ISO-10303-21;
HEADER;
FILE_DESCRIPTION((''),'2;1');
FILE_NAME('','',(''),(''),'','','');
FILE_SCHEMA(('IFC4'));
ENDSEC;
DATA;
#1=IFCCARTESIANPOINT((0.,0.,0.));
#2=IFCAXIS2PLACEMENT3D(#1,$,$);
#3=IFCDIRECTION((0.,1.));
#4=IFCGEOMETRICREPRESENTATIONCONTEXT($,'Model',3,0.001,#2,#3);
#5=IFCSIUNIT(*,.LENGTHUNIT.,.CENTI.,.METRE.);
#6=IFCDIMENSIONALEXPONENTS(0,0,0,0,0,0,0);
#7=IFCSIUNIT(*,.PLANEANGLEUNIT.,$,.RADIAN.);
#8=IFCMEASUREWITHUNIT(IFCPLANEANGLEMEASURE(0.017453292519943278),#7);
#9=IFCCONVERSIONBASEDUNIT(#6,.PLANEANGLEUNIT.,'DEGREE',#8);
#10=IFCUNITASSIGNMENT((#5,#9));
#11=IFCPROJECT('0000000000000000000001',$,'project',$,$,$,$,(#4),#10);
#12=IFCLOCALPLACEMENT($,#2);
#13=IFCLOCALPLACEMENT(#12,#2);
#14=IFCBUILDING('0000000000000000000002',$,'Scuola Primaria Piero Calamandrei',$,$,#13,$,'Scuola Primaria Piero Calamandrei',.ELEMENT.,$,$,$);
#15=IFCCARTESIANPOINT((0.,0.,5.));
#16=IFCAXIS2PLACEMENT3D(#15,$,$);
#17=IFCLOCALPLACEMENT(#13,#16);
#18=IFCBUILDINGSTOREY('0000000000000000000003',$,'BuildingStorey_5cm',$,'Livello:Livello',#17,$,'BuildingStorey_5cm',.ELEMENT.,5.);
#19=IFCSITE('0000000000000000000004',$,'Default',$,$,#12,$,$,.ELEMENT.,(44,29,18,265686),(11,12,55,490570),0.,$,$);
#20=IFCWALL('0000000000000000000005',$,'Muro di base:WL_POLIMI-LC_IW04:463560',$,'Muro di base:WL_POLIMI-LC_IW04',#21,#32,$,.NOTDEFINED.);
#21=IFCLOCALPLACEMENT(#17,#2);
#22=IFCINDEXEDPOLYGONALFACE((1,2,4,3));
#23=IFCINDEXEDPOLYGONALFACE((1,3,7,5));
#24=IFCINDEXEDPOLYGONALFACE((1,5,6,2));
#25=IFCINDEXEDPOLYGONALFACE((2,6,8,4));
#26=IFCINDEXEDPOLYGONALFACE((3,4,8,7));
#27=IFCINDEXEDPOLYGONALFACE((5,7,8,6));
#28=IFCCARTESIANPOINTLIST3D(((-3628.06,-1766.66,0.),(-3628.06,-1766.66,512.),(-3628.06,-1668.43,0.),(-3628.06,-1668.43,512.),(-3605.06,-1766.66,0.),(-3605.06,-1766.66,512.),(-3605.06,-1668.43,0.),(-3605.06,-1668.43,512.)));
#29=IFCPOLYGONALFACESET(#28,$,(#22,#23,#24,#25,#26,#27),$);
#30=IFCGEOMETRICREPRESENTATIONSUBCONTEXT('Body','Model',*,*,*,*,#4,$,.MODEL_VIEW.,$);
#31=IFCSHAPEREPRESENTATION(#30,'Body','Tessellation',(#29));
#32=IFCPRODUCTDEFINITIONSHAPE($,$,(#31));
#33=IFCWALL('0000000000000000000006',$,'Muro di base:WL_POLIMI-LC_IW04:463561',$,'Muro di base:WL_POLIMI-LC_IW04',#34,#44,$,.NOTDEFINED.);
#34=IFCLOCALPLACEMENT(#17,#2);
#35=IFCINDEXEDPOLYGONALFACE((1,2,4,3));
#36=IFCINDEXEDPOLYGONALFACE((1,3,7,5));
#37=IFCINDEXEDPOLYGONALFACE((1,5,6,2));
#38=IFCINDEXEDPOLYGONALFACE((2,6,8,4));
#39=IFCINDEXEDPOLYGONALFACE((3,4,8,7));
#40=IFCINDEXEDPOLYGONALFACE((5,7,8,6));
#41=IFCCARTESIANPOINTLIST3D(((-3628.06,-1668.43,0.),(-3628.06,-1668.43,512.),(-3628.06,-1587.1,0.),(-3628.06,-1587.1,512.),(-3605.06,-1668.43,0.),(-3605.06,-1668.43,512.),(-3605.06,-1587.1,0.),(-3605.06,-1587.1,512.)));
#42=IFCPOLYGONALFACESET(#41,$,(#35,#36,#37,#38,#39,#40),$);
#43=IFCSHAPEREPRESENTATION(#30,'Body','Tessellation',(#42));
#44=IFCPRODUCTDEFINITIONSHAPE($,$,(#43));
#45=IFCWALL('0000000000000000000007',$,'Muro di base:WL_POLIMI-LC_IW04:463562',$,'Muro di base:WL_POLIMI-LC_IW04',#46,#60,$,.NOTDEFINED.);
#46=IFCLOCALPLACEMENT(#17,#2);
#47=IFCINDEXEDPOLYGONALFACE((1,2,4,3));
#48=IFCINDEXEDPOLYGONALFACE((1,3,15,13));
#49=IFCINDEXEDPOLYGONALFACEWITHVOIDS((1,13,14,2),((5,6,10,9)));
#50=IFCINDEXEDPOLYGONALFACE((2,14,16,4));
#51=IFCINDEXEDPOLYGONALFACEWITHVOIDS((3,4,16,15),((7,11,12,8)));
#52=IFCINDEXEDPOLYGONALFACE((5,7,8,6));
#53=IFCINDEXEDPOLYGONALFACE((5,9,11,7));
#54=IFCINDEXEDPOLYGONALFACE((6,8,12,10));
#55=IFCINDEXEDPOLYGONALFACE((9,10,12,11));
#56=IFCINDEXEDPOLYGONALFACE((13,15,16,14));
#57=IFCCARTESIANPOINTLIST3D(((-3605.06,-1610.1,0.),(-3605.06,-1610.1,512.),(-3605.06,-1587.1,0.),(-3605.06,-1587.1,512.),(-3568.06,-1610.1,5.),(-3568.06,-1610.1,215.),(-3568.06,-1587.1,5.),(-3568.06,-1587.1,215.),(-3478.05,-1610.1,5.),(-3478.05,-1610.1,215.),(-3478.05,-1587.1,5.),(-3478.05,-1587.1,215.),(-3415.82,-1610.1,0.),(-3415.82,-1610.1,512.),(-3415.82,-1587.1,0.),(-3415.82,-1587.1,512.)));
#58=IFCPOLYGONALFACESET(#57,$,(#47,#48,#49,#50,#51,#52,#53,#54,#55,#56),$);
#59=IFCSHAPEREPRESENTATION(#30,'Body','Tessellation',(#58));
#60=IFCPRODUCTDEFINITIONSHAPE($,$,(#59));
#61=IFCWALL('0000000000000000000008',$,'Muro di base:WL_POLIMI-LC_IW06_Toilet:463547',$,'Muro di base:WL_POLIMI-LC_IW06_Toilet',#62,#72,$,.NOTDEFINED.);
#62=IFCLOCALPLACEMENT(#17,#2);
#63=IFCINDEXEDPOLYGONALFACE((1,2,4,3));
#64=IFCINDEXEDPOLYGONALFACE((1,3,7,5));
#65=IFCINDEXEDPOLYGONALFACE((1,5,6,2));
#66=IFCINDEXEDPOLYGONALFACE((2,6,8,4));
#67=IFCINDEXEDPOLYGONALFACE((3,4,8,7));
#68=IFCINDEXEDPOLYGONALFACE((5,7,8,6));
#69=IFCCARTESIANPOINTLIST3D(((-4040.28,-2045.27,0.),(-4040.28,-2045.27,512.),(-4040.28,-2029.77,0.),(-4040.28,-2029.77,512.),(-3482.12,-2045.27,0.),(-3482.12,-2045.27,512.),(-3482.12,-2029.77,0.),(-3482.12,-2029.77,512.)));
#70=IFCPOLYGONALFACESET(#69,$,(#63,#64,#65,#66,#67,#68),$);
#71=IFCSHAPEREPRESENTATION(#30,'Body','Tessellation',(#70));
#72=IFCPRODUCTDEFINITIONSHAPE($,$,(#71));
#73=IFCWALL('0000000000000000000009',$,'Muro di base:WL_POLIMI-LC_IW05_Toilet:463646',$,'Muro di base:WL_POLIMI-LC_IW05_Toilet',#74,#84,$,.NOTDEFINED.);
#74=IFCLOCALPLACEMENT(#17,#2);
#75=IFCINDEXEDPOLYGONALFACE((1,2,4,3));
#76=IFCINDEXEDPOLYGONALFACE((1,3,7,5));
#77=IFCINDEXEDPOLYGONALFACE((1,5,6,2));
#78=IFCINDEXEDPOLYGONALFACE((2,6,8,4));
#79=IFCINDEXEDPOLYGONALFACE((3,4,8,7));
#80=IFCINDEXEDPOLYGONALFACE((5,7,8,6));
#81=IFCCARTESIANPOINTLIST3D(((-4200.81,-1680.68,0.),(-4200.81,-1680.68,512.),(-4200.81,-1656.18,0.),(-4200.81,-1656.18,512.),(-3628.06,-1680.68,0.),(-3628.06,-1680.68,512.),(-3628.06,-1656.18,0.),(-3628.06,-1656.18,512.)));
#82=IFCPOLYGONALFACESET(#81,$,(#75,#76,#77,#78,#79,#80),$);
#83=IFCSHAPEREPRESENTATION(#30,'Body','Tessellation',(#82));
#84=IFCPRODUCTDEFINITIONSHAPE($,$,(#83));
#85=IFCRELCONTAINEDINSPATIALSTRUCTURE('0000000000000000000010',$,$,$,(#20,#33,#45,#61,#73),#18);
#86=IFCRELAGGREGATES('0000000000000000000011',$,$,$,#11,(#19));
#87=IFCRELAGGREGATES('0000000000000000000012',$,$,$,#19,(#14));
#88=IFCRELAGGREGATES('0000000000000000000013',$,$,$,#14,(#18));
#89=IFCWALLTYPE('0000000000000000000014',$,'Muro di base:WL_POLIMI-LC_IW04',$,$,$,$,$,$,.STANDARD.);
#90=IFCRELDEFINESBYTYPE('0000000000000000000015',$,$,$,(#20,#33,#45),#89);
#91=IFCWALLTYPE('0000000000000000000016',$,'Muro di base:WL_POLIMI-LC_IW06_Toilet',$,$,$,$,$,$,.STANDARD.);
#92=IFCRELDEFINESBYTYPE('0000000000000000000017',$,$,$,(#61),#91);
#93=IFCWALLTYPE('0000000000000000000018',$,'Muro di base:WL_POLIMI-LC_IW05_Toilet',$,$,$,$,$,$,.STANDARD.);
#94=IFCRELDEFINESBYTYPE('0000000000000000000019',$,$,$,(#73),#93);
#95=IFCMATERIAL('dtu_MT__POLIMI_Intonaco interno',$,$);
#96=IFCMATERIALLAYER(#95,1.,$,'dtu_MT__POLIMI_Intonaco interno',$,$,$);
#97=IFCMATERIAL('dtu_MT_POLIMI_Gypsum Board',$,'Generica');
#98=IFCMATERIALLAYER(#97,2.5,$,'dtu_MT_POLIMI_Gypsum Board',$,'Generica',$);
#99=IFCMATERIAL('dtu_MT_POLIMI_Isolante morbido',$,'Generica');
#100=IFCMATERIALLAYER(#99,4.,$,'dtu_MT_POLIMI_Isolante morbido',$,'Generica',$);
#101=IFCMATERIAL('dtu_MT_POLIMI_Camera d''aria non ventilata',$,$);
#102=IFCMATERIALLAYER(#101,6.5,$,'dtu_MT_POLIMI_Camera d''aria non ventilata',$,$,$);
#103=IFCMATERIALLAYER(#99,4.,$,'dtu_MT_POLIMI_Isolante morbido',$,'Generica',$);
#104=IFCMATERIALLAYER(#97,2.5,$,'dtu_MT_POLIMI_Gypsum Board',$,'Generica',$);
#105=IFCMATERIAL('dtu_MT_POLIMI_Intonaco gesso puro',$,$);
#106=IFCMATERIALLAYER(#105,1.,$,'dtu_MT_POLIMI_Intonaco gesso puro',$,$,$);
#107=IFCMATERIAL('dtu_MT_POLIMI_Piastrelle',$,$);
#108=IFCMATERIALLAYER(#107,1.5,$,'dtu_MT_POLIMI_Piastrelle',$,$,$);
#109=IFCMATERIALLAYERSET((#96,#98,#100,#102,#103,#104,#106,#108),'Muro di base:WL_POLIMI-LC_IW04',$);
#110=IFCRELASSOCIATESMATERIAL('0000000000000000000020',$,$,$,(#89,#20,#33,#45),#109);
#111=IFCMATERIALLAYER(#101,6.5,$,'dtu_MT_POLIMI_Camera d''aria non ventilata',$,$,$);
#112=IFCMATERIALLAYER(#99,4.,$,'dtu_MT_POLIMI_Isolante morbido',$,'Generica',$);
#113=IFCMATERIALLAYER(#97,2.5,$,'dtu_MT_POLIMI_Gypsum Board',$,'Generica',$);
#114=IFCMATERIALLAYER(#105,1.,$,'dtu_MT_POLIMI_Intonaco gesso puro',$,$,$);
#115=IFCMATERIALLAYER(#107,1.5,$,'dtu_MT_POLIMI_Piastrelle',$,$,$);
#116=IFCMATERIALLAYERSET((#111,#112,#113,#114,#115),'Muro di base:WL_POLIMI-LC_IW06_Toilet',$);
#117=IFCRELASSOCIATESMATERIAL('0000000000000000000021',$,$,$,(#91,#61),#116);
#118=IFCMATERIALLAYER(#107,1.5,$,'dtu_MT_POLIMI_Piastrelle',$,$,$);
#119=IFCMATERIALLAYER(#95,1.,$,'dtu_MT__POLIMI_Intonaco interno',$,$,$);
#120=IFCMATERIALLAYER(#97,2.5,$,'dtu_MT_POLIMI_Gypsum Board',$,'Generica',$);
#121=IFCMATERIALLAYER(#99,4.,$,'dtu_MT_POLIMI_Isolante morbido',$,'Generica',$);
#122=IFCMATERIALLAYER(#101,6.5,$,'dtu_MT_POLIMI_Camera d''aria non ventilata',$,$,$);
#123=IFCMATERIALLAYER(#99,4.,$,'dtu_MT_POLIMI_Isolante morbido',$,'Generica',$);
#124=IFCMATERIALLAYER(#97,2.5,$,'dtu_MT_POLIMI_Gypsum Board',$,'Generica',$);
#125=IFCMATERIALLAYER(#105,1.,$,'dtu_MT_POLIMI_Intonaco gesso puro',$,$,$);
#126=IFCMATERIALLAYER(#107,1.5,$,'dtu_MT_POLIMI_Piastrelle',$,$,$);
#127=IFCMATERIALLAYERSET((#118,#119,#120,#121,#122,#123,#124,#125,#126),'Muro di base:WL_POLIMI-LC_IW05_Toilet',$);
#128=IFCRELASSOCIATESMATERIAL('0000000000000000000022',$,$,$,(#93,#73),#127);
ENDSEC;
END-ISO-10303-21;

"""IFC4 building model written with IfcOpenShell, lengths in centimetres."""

from ifc_helpers import new_model, entity, si_unit, converted_unit, direction, frame, frame_2d, origin, place, context, subcontext, project, spatial, rectangle, extrude, material, layer, layer_set, layer_usage, type_object, element, save


model = new_model("IFC4")

# Units and contexts
model_context = context("Model", 3, precision=0.001, world=origin(), true_north=direction((0.0, 1.0)))
body_context = subcontext(model_context, "Body", "Model", "MODEL_VIEW")
ifc_project = project(units=[si_unit("LENGTHUNIT", "METRE", prefix="CENTI"), converted_unit("PLANEANGLEUNIT", "DEGREE", entity("IfcPlaneAngleMeasure", 0.017453292519943278), si_unit("PLANEANGLEUNIT", "RADIAN"), dimensions=[0, 0, 0, 0, 0, 0, 0])], contexts=[model_context])

# Site, building, storey
site_placement = place(None, origin())
site = spatial("IfcSite", under=ifc_project, at=site_placement, Name="Default", CompositionType="ELEMENT", RefLatitude=(44, 29, 18, 265686), RefLongitude=(11, 12, 55, 490570), RefElevation=0.0)
building_placement = place(site_placement, origin())
building = spatial("IfcBuilding", under=site, at=building_placement, Name="Scuola Primaria Piero Calamandrei", LongName="Scuola Primaria Piero Calamandrei", CompositionType="ELEMENT")
storey_placement = place(building_placement, frame((0.0, 0.0, 5.0)))
storey = spatial("IfcBuildingStorey", under=building, at=storey_placement, Name="BuildingStorey_5cm", ObjectType="Livello:Livello", LongName="BuildingStorey_5cm", CompositionType="ELEMENT", Elevation=5.0)

# Shared definitions
ifc_material_1 = material(Name="dtu_MT_POLIMI_Intonaco gesso puro")

# Shared definitions
ifc_material_2 = material(Name="dtu_MT_POLIMI_Isolante morbido", Category="Generica")
ifc_material_3 = material(Name="dtu_MT_POLIMI_Gypsum Board", Category="Generica")
ifc_material_4 = material(Name="dtu_MT__POLIMI_Intonaco interno")

# Shared definitions
ifc_material_5 = material(Name="dtu_MT_POLIMI_Camera d'aria non ventilata")

# Walls
ifc_layer_1 = layer(ifc_material_4, 1.0, Name="dtu_MT__POLIMI_Intonaco interno")
ifc_layer_2 = layer(ifc_material_3, 2.5, Name="dtu_MT_POLIMI_Gypsum Board", Category="Generica")
ifc_layer_3 = layer(ifc_material_2, 4.0, Name="dtu_MT_POLIMI_Isolante morbido", Category="Generica")
ifc_layer_4 = layer(ifc_material_5, 6.5, Name="dtu_MT_POLIMI_Camera d'aria non ventilata")
ifc_layer_5 = layer(ifc_material_2, 4.0, Name="dtu_MT_POLIMI_Isolante morbido", Category="Generica")
ifc_layer_6 = layer(ifc_material_3, 2.5, Name="dtu_MT_POLIMI_Gypsum Board", Category="Generica")
ifc_layer_7 = layer(ifc_material_1, 1.0, Name="dtu_MT_POLIMI_Intonaco gesso puro")
ifc_material_6 = material(Name="dtu_MT_POLIMI_Piastrelle")
ifc_layer_8 = layer(ifc_material_6, 1.5, Name="dtu_MT_POLIMI_Piastrelle")
ifc_layer_set_1 = layer_set([ifc_layer_1, ifc_layer_2, ifc_layer_3, ifc_layer_4, ifc_layer_5, ifc_layer_6, ifc_layer_7, ifc_layer_8], Name="Muro di base:WL_POLIMI-LC_IW04")
wall_type_1 = type_object("IfcWallType", Name="Muro di base:WL_POLIMI-LC_IW04", PredefinedType="STANDARD", material=ifc_layer_set_1)
ifc_layer_usage_1 = layer_usage(ifc_layer_set_1, "AXIS2", "NEGATIVE", 11.5)
wall_1_placement = place(storey_placement, frame((-3616.56, -1766.66, 0.0), z_axis=(0.0, 0.0, 1.0), x_axis=(0.0, 1.0, 0.0)))
element("IfcWall", 1, at=wall_1_placement, inside=storey, type_object=wall_type_1, material=ifc_layer_usage_1, Name="Muro di base:WL_POLIMI-LC_IW04:463560", ObjectType="Muro di base:WL_POLIMI-LC_IW04", PredefinedType="NOTDEFINED", context=body_context, shape_type="SweptSolid", body=[
    extrude(rectangle(XDim=98.23, YDim=23.0, at=frame_2d((49.12, 0.0), x_axis=(-1.0, 0.0))), origin(), (0.0, 0.0, 1.0), 512.0),
])
ifc_layer_usage_2 = layer_usage(ifc_layer_set_1, "AXIS2", "NEGATIVE", 11.5)
wall_2_placement = place(storey_placement, frame((-3616.56, -1668.43, 0.0), z_axis=(0.0, 0.0, 1.0), x_axis=(0.0, 1.0, 0.0)))
element("IfcWall", 2, at=wall_2_placement, inside=storey, type_object=wall_type_1, material=ifc_layer_usage_2, Name="Muro di base:WL_POLIMI-LC_IW04:463561", ObjectType="Muro di base:WL_POLIMI-LC_IW04", PredefinedType="NOTDEFINED", context=body_context, shape_type="SweptSolid", body=[
    extrude(rectangle(XDim=81.33, YDim=23.0, at=frame_2d((40.66, 0.0), x_axis=(-1.0, 0.0))), origin(), (0.0, 0.0, 1.0), 512.0),
])

# Wall, opening
ifc_layer_usage_3 = layer_usage(ifc_layer_set_1, "AXIS2", "NEGATIVE", 11.5)
wall_3_placement = place(storey_placement, frame((-3605.06, -1598.6, 0.0)))
wall_3 = element("IfcWall", 3, at=wall_3_placement, inside=storey, type_object=wall_type_1, material=ifc_layer_usage_3, Name="Muro di base:WL_POLIMI-LC_IW04:463562", ObjectType="Muro di base:WL_POLIMI-LC_IW04", PredefinedType="NOTDEFINED", context=body_context, shape_type="SweptSolid", body=[
    extrude(rectangle(XDim=189.23, YDim=23.0, at=frame_2d((94.62, 0.0), x_axis=(-1.0, 0.0))), origin(), (0.0, 0.0, 1.0), 512.0),
])
opening_1_placement = place(wall_3_placement, frame((127.0, 11.5, 5.0)))
element("IfcOpeningElement", 4, at=opening_1_placement, cuts=wall_3, PredefinedType="OPENING", context=body_context, shape_type="SweptSolid", body=[
    extrude(rectangle(XDim=210.0, YDim=90.0, at=frame_2d((105.0, 45.0), x_axis=(-1.0, 0.0))), frame((0.0, 0.0, 0.0), z_axis=(0.0, -1.0, 0.0), x_axis=(0.0, 0.0, 1.0)), (0.0, 0.0, 1.0), 23.0),
])

# Walls
ifc_layer_9 = layer(ifc_material_5, 6.5, Name="dtu_MT_POLIMI_Camera d'aria non ventilata")
ifc_layer_10 = layer(ifc_material_2, 4.0, Name="dtu_MT_POLIMI_Isolante morbido", Category="Generica")
ifc_layer_11 = layer(ifc_material_3, 2.5, Name="dtu_MT_POLIMI_Gypsum Board", Category="Generica")
ifc_layer_12 = layer(ifc_material_1, 1.0, Name="dtu_MT_POLIMI_Intonaco gesso puro")
ifc_layer_13 = layer(ifc_material_6, 1.5, Name="dtu_MT_POLIMI_Piastrelle")
ifc_layer_set_2 = layer_set([ifc_layer_9, ifc_layer_10, ifc_layer_11, ifc_layer_12, ifc_layer_13], Name="Muro di base:WL_POLIMI-LC_IW06_Toilet")
ifc_layer_usage_4 = layer_usage(ifc_layer_set_2, "AXIS2", "NEGATIVE", 7.75)
wall_type_2 = type_object("IfcWallType", Name="Muro di base:WL_POLIMI-LC_IW06_Toilet", PredefinedType="STANDARD", material=ifc_layer_set_2)
wall_4_placement = place(storey_placement, frame((-4040.28, -2037.52, 0.0)))
element("IfcWall", 5, at=wall_4_placement, inside=storey, type_object=wall_type_2, material=ifc_layer_usage_4, Name="Muro di base:WL_POLIMI-LC_IW06_Toilet:463547", ObjectType="Muro di base:WL_POLIMI-LC_IW06_Toilet", PredefinedType="NOTDEFINED", context=body_context, shape_type="SweptSolid", body=[
    extrude(rectangle(XDim=558.16, YDim=15.5, at=frame_2d((279.08, 0.0), x_axis=(-1.0, 0.0))), origin(), (0.0, 0.0, 1.0), 512.0),
])
ifc_layer_14 = layer(ifc_material_6, 1.5, Name="dtu_MT_POLIMI_Piastrelle")
ifc_layer_15 = layer(ifc_material_4, 1.0, Name="dtu_MT__POLIMI_Intonaco interno")
ifc_layer_16 = layer(ifc_material_3, 2.5, Name="dtu_MT_POLIMI_Gypsum Board", Category="Generica")
ifc_layer_17 = layer(ifc_material_2, 4.0, Name="dtu_MT_POLIMI_Isolante morbido", Category="Generica")
ifc_layer_18 = layer(ifc_material_5, 6.5, Name="dtu_MT_POLIMI_Camera d'aria non ventilata")
ifc_layer_19 = layer(ifc_material_2, 4.0, Name="dtu_MT_POLIMI_Isolante morbido", Category="Generica")
ifc_layer_20 = layer(ifc_material_3, 2.5, Name="dtu_MT_POLIMI_Gypsum Board", Category="Generica")
ifc_layer_21 = layer(ifc_material_1, 1.0, Name="dtu_MT_POLIMI_Intonaco gesso puro")
ifc_layer_22 = layer(ifc_material_6, 1.5, Name="dtu_MT_POLIMI_Piastrelle")
ifc_layer_set_3 = layer_set([ifc_layer_14, ifc_layer_15, ifc_layer_16, ifc_layer_17, ifc_layer_18, ifc_layer_19, ifc_layer_20, ifc_layer_21, ifc_layer_22], Name="Muro di base:WL_POLIMI-LC_IW05_Toilet")
ifc_layer_usage_5 = layer_usage(ifc_layer_set_3, "AXIS2", "NEGATIVE", 12.25)
wall_type_3 = type_object("IfcWallType", Name="Muro di base:WL_POLIMI-LC_IW05_Toilet", PredefinedType="STANDARD", material=ifc_layer_set_3)
wall_5_placement = place(storey_placement, frame((-4200.81, -1668.43, 0.0)))
element("IfcWall", 6, at=wall_5_placement, inside=storey, type_object=wall_type_3, material=ifc_layer_usage_5, Name="Muro di base:WL_POLIMI-LC_IW05_Toilet:463646", ObjectType="Muro di base:WL_POLIMI-LC_IW05_Toilet", PredefinedType="NOTDEFINED", context=body_context, shape_type="SweptSolid", body=[
    extrude(rectangle(XDim=572.75, YDim=24.5, at=frame_2d((286.38, 0.0), x_axis=(-1.0, 0.0))), origin(), (0.0, 0.0, 1.0), 512.0),
])

save(model, "model.ifc")
